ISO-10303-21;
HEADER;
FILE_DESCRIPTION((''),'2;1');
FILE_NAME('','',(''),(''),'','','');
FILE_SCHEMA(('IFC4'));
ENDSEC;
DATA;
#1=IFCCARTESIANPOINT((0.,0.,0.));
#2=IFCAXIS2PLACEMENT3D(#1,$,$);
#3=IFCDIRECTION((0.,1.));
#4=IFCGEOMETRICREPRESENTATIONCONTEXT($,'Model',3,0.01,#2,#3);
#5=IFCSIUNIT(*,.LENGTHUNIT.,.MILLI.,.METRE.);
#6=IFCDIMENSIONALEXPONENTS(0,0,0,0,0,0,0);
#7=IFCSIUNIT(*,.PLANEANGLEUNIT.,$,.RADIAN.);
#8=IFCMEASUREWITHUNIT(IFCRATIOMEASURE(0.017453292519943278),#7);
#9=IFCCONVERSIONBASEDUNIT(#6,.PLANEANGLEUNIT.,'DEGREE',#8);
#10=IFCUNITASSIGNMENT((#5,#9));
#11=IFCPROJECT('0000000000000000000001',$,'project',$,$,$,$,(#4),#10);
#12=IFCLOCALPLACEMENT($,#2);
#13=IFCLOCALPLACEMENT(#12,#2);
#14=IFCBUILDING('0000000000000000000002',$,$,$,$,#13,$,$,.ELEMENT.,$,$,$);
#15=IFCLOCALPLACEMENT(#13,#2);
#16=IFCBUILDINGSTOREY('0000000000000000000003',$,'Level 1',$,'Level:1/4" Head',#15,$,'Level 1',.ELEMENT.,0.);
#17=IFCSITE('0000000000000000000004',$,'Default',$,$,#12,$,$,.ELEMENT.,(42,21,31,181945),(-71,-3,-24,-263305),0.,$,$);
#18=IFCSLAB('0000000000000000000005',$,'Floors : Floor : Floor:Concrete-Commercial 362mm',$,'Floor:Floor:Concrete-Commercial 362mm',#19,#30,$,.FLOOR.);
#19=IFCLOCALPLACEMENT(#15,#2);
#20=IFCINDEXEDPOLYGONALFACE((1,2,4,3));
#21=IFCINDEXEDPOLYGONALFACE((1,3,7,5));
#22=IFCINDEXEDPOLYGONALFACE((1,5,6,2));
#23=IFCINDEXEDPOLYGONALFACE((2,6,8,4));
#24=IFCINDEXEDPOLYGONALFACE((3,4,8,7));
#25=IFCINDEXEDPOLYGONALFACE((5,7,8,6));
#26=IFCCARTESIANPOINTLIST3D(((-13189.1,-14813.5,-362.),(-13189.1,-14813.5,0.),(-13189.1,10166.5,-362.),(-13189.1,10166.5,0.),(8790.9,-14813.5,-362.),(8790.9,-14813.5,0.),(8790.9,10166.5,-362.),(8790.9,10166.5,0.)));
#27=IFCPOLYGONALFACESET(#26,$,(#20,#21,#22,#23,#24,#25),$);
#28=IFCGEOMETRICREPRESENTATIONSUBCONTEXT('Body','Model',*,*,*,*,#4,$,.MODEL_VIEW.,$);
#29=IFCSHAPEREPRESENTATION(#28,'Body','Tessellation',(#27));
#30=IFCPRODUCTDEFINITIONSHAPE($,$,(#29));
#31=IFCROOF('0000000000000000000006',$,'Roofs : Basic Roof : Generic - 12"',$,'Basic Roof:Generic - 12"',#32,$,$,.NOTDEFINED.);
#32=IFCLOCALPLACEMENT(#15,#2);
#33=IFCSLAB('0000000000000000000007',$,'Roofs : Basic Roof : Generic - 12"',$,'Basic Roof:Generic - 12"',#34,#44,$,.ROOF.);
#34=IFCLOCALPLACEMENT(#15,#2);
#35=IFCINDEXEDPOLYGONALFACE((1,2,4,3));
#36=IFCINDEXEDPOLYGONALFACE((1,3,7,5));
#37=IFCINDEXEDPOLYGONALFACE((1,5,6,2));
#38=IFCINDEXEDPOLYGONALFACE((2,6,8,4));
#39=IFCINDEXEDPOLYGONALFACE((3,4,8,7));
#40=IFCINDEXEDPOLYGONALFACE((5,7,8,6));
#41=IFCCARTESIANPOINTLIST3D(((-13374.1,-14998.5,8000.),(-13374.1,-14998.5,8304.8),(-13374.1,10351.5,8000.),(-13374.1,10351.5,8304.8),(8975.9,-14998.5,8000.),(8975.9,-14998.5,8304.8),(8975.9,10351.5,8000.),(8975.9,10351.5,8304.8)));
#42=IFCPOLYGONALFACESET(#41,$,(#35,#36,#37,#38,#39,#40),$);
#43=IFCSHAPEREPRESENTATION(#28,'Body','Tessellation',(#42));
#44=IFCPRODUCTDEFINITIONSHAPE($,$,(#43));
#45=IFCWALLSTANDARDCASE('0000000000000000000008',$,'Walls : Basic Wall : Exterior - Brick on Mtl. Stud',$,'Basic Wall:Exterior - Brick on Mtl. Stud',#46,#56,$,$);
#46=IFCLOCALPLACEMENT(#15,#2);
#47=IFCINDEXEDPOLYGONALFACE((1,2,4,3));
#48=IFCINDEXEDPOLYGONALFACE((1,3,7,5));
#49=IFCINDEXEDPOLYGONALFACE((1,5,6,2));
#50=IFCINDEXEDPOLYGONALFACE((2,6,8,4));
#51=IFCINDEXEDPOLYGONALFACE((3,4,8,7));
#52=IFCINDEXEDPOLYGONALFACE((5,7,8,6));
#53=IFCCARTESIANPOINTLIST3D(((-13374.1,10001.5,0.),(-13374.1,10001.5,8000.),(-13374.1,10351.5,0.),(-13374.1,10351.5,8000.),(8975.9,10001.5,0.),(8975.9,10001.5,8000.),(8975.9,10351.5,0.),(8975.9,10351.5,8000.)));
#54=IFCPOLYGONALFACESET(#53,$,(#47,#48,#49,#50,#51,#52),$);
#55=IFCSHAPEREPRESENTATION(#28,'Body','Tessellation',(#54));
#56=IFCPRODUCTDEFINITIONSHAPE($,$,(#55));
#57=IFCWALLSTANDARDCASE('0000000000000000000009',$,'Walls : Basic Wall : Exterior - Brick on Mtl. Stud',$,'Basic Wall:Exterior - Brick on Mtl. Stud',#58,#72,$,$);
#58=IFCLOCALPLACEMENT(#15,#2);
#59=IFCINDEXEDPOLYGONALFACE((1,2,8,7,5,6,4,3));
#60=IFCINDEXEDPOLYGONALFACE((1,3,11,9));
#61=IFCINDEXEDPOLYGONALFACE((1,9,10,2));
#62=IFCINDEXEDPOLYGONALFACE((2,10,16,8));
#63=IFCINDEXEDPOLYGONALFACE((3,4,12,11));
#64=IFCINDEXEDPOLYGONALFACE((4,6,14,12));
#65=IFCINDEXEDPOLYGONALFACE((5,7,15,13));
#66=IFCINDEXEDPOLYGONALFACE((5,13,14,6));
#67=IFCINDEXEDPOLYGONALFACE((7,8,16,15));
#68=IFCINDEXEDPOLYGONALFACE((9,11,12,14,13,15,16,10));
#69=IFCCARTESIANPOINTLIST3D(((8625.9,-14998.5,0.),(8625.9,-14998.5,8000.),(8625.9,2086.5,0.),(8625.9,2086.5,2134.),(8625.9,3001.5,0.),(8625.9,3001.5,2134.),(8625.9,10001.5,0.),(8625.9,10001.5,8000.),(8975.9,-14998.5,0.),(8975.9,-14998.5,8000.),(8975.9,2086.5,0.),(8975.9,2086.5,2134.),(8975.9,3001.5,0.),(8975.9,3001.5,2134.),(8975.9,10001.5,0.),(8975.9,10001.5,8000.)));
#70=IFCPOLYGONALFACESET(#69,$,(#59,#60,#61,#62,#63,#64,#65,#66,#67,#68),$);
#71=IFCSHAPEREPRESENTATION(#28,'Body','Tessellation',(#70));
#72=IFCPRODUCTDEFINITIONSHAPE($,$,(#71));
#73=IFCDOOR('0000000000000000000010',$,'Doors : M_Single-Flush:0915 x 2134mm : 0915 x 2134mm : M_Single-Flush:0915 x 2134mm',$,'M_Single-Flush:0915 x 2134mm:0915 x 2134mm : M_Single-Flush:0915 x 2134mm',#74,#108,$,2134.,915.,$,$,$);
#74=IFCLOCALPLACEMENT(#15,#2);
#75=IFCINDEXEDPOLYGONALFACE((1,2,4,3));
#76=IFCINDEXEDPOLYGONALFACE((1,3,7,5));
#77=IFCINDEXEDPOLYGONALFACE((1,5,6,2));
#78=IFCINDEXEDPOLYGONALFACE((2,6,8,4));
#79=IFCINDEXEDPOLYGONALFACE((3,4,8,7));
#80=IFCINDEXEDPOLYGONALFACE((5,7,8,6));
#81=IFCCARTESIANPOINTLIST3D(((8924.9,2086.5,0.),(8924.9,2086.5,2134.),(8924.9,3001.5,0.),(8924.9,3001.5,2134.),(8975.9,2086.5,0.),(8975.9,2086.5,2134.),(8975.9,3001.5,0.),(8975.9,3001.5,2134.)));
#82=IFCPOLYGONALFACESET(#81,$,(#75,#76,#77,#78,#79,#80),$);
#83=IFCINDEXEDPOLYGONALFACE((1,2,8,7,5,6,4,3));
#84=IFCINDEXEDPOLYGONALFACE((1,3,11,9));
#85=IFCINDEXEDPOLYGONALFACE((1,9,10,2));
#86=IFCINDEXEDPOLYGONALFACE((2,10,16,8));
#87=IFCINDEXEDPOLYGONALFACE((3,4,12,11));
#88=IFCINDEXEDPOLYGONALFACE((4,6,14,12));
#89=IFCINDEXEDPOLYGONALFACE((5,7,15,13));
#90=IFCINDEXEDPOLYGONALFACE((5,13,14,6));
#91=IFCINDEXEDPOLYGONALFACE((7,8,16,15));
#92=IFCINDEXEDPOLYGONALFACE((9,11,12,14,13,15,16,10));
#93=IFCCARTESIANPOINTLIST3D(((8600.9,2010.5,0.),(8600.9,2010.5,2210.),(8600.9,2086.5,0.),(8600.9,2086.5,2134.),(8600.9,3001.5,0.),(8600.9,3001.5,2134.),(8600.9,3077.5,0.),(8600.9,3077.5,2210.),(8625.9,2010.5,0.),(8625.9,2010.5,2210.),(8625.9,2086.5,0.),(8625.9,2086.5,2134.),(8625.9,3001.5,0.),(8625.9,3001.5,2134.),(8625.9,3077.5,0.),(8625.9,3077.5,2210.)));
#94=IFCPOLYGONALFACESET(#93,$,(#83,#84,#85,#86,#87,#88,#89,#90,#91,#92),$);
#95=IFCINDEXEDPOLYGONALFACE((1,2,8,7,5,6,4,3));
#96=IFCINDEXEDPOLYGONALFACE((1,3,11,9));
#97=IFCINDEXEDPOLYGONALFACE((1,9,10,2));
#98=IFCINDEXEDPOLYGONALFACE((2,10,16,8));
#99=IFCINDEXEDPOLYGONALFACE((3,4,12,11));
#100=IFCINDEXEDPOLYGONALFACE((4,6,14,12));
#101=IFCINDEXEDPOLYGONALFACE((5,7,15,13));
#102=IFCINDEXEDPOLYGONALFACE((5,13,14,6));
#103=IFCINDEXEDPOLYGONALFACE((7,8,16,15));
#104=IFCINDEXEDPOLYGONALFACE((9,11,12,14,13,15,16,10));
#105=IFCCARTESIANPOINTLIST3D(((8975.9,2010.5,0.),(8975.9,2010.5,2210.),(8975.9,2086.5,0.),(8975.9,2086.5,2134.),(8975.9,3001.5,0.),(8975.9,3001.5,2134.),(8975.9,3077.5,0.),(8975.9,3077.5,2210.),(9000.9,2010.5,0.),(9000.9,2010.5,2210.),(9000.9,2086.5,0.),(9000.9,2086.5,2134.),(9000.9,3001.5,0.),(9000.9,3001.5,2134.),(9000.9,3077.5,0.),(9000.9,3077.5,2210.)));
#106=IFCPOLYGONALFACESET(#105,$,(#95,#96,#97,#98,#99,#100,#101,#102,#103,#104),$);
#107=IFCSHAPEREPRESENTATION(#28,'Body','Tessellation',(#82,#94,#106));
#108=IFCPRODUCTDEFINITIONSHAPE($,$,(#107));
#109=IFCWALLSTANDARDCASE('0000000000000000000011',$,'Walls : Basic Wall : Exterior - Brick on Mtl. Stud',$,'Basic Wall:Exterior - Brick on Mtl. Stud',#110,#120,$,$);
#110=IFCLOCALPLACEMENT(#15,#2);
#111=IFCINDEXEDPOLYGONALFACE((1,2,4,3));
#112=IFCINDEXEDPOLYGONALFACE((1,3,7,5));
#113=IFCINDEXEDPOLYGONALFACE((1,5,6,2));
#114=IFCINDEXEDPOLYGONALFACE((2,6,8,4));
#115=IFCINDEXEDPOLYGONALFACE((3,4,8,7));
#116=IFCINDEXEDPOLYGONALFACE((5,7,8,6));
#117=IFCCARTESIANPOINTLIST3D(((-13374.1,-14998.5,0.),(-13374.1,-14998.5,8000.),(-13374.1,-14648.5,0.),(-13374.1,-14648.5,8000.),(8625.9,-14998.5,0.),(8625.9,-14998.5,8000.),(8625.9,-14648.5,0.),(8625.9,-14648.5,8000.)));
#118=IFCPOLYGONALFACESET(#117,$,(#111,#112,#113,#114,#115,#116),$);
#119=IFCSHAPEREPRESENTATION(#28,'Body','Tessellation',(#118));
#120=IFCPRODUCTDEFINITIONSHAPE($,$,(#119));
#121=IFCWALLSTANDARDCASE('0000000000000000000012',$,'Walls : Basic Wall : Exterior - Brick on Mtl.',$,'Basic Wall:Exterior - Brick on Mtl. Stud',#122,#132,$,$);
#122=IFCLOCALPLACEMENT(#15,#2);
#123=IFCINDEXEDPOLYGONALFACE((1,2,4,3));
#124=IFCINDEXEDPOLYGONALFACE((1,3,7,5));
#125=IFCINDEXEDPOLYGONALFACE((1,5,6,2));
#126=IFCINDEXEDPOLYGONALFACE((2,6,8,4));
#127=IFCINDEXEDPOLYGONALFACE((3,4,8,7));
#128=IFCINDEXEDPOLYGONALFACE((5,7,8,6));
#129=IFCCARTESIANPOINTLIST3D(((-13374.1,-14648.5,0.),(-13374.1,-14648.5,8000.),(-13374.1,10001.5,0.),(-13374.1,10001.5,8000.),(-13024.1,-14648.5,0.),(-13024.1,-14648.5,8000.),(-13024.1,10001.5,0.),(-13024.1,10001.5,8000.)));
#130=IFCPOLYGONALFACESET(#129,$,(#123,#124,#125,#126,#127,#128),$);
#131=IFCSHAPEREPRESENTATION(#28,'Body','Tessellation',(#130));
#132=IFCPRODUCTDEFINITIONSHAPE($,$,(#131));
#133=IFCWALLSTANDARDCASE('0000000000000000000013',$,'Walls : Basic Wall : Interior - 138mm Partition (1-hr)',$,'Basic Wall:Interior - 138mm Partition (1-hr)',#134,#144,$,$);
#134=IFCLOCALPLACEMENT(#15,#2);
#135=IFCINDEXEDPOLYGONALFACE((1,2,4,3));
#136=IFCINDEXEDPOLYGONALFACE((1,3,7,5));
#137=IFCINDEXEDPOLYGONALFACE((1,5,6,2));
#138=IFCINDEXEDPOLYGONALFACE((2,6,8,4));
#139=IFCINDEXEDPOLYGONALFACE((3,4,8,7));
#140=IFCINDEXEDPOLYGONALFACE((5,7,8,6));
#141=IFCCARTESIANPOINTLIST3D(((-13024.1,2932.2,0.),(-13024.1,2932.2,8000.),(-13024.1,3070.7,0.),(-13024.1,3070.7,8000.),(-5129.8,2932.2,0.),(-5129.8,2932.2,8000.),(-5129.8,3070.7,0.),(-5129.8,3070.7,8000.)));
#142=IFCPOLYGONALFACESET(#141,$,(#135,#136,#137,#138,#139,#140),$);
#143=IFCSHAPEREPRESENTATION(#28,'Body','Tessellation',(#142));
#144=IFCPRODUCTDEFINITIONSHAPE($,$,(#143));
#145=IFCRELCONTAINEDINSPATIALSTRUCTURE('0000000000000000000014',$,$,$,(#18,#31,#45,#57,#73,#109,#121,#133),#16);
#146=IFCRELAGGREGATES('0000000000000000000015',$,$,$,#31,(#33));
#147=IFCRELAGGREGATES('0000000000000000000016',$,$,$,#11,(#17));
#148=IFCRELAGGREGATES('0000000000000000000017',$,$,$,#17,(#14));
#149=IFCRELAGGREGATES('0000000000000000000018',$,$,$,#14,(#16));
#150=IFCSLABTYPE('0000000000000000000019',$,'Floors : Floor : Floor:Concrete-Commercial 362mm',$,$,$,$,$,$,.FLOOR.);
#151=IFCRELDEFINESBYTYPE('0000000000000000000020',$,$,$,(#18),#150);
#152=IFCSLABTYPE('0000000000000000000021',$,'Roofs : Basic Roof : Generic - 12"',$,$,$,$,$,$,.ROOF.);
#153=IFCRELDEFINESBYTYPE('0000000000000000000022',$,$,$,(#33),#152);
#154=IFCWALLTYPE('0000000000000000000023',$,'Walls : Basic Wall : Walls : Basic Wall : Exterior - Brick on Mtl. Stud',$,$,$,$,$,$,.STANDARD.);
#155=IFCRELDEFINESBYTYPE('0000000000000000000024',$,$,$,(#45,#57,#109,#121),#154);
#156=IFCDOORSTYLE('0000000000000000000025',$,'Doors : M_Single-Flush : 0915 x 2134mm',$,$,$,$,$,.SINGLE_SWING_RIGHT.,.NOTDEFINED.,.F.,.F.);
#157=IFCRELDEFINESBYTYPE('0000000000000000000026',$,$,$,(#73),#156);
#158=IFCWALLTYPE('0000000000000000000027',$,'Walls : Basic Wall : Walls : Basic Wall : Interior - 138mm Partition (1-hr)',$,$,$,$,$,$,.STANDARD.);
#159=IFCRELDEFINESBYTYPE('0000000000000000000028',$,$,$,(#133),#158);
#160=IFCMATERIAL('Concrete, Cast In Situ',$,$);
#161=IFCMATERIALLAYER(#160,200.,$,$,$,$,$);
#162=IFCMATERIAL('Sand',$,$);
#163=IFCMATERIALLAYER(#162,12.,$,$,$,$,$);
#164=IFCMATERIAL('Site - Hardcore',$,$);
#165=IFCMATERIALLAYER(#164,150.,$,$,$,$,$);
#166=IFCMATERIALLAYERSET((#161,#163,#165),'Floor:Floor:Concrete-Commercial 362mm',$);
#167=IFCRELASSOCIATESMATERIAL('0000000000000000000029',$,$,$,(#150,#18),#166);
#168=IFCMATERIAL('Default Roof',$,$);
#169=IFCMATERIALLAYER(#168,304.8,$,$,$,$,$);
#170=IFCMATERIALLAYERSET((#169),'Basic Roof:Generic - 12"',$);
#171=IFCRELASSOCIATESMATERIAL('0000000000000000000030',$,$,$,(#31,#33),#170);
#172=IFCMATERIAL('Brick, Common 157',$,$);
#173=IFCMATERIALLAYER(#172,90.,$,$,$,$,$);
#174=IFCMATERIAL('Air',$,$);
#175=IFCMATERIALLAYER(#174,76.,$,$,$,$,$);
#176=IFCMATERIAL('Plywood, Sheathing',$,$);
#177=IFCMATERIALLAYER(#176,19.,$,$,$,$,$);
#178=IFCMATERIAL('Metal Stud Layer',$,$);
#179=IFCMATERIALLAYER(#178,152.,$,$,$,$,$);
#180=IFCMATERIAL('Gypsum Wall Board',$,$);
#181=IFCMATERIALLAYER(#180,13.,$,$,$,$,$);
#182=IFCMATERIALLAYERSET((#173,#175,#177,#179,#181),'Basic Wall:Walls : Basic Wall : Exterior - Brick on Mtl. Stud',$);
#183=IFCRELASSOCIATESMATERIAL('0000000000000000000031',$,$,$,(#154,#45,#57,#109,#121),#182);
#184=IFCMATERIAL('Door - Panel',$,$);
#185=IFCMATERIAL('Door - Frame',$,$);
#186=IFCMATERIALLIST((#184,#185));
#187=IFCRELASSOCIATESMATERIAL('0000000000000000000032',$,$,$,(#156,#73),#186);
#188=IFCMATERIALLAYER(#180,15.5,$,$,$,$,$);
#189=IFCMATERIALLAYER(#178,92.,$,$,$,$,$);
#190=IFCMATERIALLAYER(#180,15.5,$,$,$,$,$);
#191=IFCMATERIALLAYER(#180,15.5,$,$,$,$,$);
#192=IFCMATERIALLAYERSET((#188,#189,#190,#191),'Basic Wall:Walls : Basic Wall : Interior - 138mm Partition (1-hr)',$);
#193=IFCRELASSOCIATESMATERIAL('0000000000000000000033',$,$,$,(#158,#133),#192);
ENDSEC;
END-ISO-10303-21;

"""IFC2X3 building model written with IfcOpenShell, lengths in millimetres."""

from ifc_helpers import new_model, entity, si_unit, converted_unit, direction, frame, frame_2d, origin, origin_2d_with_axis, place, context, subcontext, project, spatial, polyline, rectangle, outline, extrude, source, transform, mapped, material, material_list, layer, layer_set, layer_usage, type_object, type_shapes, element, fill, aggregate, save


model = new_model("IFC2X3")

# Units and contexts
model_context = context("Model", 3, precision=0.01, world=origin(), true_north=direction((0.0, 1.0)))
body_context = subcontext(model_context, "Body", "Model", "MODEL_VIEW")
ifc_project = project(units=[si_unit("LENGTHUNIT", "METRE", prefix="MILLI"), converted_unit("PLANEANGLEUNIT", "DEGREE", entity("IfcRatioMeasure", 0.017453292519943278), si_unit("PLANEANGLEUNIT", "RADIAN"), dimensions=[0, 0, 0, 0, 0, 0, 0])], contexts=[model_context])

# Site, building, storey
site_placement = place(None, origin())
site = spatial("IfcSite", under=ifc_project, at=site_placement, Name="Default", CompositionType="ELEMENT", RefLatitude=(42, 21, 31, 181945), RefLongitude=(-71, -3, -24, -263305), RefElevation=0.0)
building_placement = place(site_placement, origin())
building = spatial("IfcBuilding", under=site, at=building_placement, CompositionType="ELEMENT")
storey_placement = place(building_placement, origin())
storey = spatial("IfcBuildingStorey", under=building, at=storey_placement, Name="Level 1", ObjectType="Level:1/4\" Head", LongName="Level 1", CompositionType="ELEMENT", Elevation=0.0)

# Slab
ifc_material_1 = material(Name="Concrete, Cast In Situ")
ifc_layer_1 = layer(ifc_material_1, 200.0)
ifc_material_2 = material(Name="Sand")
ifc_layer_2 = layer(ifc_material_2, 12.0)
ifc_material_3 = material(Name="Site - Hardcore")
ifc_layer_3 = layer(ifc_material_3, 150.0)
ifc_layer_set_1 = layer_set([ifc_layer_1, ifc_layer_2, ifc_layer_3], Name="Floor:Floor:Concrete-Commercial 362mm")
ifc_layer_usage_1 = layer_usage(ifc_layer_set_1, "AXIS3", "POSITIVE", 0.0)
slab_type_1 = type_object("IfcSlabType", Name="Floors : Floor : Floor:Concrete-Commercial 362mm", PredefinedType="FLOOR", material=ifc_layer_set_1)
slab_1_placement = place(storey_placement, origin())
element("IfcSlab", 1, at=slab_1_placement, inside=storey, type_object=slab_type_1, material=ifc_layer_usage_1, Name="Floors : Floor : Floor:Concrete-Commercial 362mm", ObjectType="Floor:Floor:Concrete-Commercial 362mm", PredefinedType="FLOOR", context=body_context, shape_type="SweptSolid", body=[
    extrude(rectangle(XDim=24980.0, YDim=21980.0, at=origin_2d_with_axis()), frame((-2199.1, -2323.5, 0.0), z_axis=(0.0, 0.0, -1.0), x_axis=(0.0, 1.0, 0.0)), (0.0, 0.0, 1.0), 362.0),
])

# Roof, slab
ifc_material_4 = material(Name="Default Roof")
ifc_layer_4 = layer(ifc_material_4, 304.8)
ifc_layer_set_2 = layer_set([ifc_layer_4], Name="Basic Roof:Generic - 12\"")
roof_placement = place(storey_placement, frame((-13374.1, -14998.5, 8000.0)))
roof = element("IfcRoof", 2, at=roof_placement, inside=storey, material=ifc_layer_set_2, Name="Roofs : Basic Roof : Generic - 12\"", ObjectType="Basic Roof:Generic - 12\"", ShapeType="NOTDEFINED")
slab_type_2 = type_object("IfcSlabType", Name="Roofs : Basic Roof : Generic - 12\"", PredefinedType="ROOF")
slab_2_placement = place(roof_placement, origin())
slab_2 = element("IfcSlab", 3, at=slab_2_placement, type_object=slab_type_2, material=ifc_layer_set_2, Name="Roofs : Basic Roof : Generic - 12\"", ObjectType="Basic Roof:Generic - 12\"", PredefinedType="ROOF", context=body_context, shape_type="SweptSolid", body=[
    extrude(rectangle(XDim=22350.0, YDim=25350.0, at=origin_2d_with_axis()), frame((11175.0, 12675.0, 0.0)), (0.0, 0.0, 1.0), 304.8),
])
aggregate(roof, [slab_2])

# Wall
ifc_material_5 = material(Name="Brick, Common 157")
ifc_layer_5 = layer(ifc_material_5, 90.0)
ifc_material_6 = material(Name="Air")
ifc_layer_6 = layer(ifc_material_6, 76.0)
ifc_material_7 = material(Name="Plywood, Sheathing")
ifc_layer_7 = layer(ifc_material_7, 19.0)
ifc_material_8 = material(Name="Metal Stud Layer")
ifc_layer_8 = layer(ifc_material_8, 152.0)
ifc_material_9 = material(Name="Gypsum Wall Board")
ifc_layer_9 = layer(ifc_material_9, 13.0)
ifc_layer_set_3 = layer_set([ifc_layer_5, ifc_layer_6, ifc_layer_7, ifc_layer_8, ifc_layer_9], Name="Basic Wall:Walls : Basic Wall : Exterior - Brick on Mtl. Stud")
ifc_layer_usage_2 = layer_usage(ifc_layer_set_3, "AXIS2", "NEGATIVE", 175.0)
wall_type_1 = type_object("IfcWallType", Name="Walls : Basic Wall : Walls : Basic Wall : Exterior - Brick on Mtl. Stud", PredefinedType="STANDARD", material=ifc_layer_set_3)
wall_1_placement = place(storey_placement, frame((-13374.1, 10176.5, 0.0)))
element("IfcWallStandardCase", 4, at=wall_1_placement, inside=storey, type_object=wall_type_1, material=ifc_layer_usage_2, Name="Walls : Basic Wall : Exterior - Brick on Mtl. Stud", ObjectType="Basic Wall:Exterior - Brick on Mtl. Stud", context=body_context, shape_type="SweptSolid", body=[
    extrude(rectangle(XDim=22350.0, YDim=350.0, at=frame_2d((11175.0, 0.0), x_axis=(-1.0, 0.0))), origin(), (0.0, 0.0, 1.0), 8000.0),
])

# Wall, opening, door
wall_2_placement = place(storey_placement, frame((8800.9, 10001.5, 0.0), z_axis=(0.0, 0.0, 1.0), x_axis=(0.0, -1.0, 0.0)))
wall_2 = element("IfcWallStandardCase", 5, at=wall_2_placement, inside=storey, type_object=wall_type_1, material=ifc_layer_usage_2, Name="Walls : Basic Wall : Exterior - Brick on Mtl. Stud", ObjectType="Basic Wall:Exterior - Brick on Mtl. Stud", context=body_context, shape_type="SweptSolid", body=[
    extrude(rectangle(XDim=25000.0, YDim=350.0, at=frame_2d((12500.0, 0.0), x_axis=(1.0, 0.0))), origin(), (0.0, 0.0, 1.0), 8000.0),
])
opening_1_placement = place(wall_2_placement, frame((7915.0, -178.5, 0.0), z_axis=(0.0, 0.0, 1.0), x_axis=(0.0, 1.0, 0.0)))
opening_1 = element("IfcOpeningElement", 6, at=opening_1_placement, cuts=wall_2, ObjectType="Opening", context=body_context, shape_type="SweptSolid", body=[
    extrude(rectangle(XDim=2134.0, YDim=915.0, at=origin_2d_with_axis()), frame((0.0, 457.5, 1067.0), z_axis=(1.0, 0.0, 0.0), x_axis=(0.0, 0.0, -1.0)), (0.0, 0.0, 1.0), 357.0),
])
ifc_material_10 = material(Name="Door - Panel")
ifc_material_11 = material(Name="Door - Frame")
ifc_material_list = material_list([ifc_material_10, ifc_material_11])
door_style_1 = type_object("IfcDoorStyle", Name="Doors : M_Single-Flush : 0915 x 2134mm", ConstructionType="NOTDEFINED", OperationType="SINGLE_SWING_RIGHT", ParameterTakesPrecedence=False, Sizeable=False, material=ifc_material_list)
shared_shape_1 = source(origin(), body_context, "Body", "SweptSolid", [
    extrude(rectangle(XDim=915.0, YDim=51.0, at=frame_2d((0.0, 0.0), x_axis=(1.0, 0.0))), frame((457.5, -29.0, 0.0), z_axis=(0.0, 0.0, 1.0), x_axis=(-1.0, 0.0, 0.0)), (0.0, 0.0, 1.0), 2134.0),
    extrude(outline(polyline([(-533.5, -1086.0), (-457.5, -1086.0), (-457.5, 1048.0), (457.5, 1048.0), (457.5, -1086.0), (533.5, -1086.0), (533.5, 1124.0), (-533.5, 1124.0), (-533.5, -1086.0)])), frame((457.5, -378.5, 1086.0), z_axis=(0.0, 1.0, 0.0), x_axis=(-1.0, 0.0, 0.0)), (0.0, 0.0, 1.0), 25.0),
    extrude(outline(polyline([(-1124.0, -533.5), (1086.0, -533.5), (1086.0, -457.5), (-1048.0, -457.5), (-1048.0, 457.5), (1086.0, 457.5), (1086.0, 533.5), (-1124.0, 533.5), (-1124.0, -533.5)])), frame((457.5, -3.5, 1086.0), z_axis=(0.0, 1.0, 0.0), x_axis=(0.0, 0.0, -1.0)), (0.0, 0.0, 1.0), 25.0),
])
type_shapes(door_style_1, [shared_shape_1])
door_1_placement = place(opening_1_placement, frame((357.0, 915.0, 0.0), z_axis=(0.0, 0.0, 1.0), x_axis=(0.0, -1.0, 0.0)))
door_1 = element("IfcDoor", 7, at=door_1_placement, inside=storey, type_object=door_style_1, material=ifc_material_list, Name="Doors : M_Single-Flush:0915 x 2134mm : 0915 x 2134mm : M_Single-Flush:0915 x 2134mm", ObjectType="M_Single-Flush:0915 x 2134mm:0915 x 2134mm : M_Single-Flush:0915 x 2134mm", OverallHeight=2134.0, OverallWidth=915.0, context=body_context, shape_type="MappedRepresentation", body=[
    mapped(shared_shape_1, transform((0.0, 0.0, 0.0), scale=1.0)),
])
fill(opening_1, door_1)

# Walls
wall_3_placement = place(storey_placement, frame((8625.9, -14823.5, 0.0), z_axis=(0.0, 0.0, 1.0), x_axis=(-1.0, 0.0, 0.0)))
element("IfcWallStandardCase", 8, at=wall_3_placement, inside=storey, type_object=wall_type_1, material=ifc_layer_usage_2, Name="Walls : Basic Wall : Exterior - Brick on Mtl. Stud", ObjectType="Basic Wall:Exterior - Brick on Mtl. Stud", context=body_context, shape_type="SweptSolid", body=[
    extrude(rectangle(XDim=22000.0, YDim=350.0, at=frame_2d((11000.0, 0.0), x_axis=(-1.0, 0.0))), origin(), (0.0, 0.0, 1.0), 8000.0),
])
wall_4_placement = place(storey_placement, frame((-13199.1, -14648.5, 0.0), z_axis=(0.0, 0.0, 1.0), x_axis=(0.0, 1.0, 0.0)))
element("IfcWallStandardCase", 9, at=wall_4_placement, inside=storey, type_object=wall_type_1, material=ifc_layer_usage_2, Name="Walls : Basic Wall : Exterior - Brick on Mtl.", ObjectType="Basic Wall:Exterior - Brick on Mtl. Stud", context=body_context, shape_type="SweptSolid", body=[
    extrude(rectangle(XDim=24650.0, YDim=350.0, at=frame_2d((12325.0, 0.0), x_axis=(-1.0, 0.0))), origin(), (0.0, 0.0, 1.0), 8000.0),
])
ifc_layer_10 = layer(ifc_material_9, 15.5)
ifc_layer_11 = layer(ifc_material_8, 92.0)
ifc_layer_12 = layer(ifc_material_9, 15.5)
ifc_layer_13 = layer(ifc_material_9, 15.5)
ifc_layer_set_4 = layer_set([ifc_layer_10, ifc_layer_11, ifc_layer_12, ifc_layer_13], Name="Basic Wall:Walls : Basic Wall : Interior - 138mm Partition (1-hr)")
ifc_layer_usage_3 = layer_usage(ifc_layer_set_4, "AXIS2", "NEGATIVE", 69.2)
wall_type_2 = type_object("IfcWallType", Name="Walls : Basic Wall : Walls : Basic Wall : Interior - 138mm Partition (1-hr)", PredefinedType="STANDARD", material=ifc_layer_set_4)
wall_5_placement = place(storey_placement, frame((-13024.1, 3001.5, 0.0)))
element("IfcWallStandardCase", 10, at=wall_5_placement, inside=storey, type_object=wall_type_2, material=ifc_layer_usage_3, Name="Walls : Basic Wall : Interior - 138mm Partition (1-hr)", ObjectType="Basic Wall:Interior - 138mm Partition (1-hr)", context=body_context, shape_type="SweptSolid", body=[
    extrude(rectangle(XDim=7894.3, YDim=138.5, at=frame_2d((3947.1, 0.0), x_axis=(-1.0, 0.0))), origin(), (0.0, 0.0, 1.0), 8000.0),
])

save(model, "model.ifc")
